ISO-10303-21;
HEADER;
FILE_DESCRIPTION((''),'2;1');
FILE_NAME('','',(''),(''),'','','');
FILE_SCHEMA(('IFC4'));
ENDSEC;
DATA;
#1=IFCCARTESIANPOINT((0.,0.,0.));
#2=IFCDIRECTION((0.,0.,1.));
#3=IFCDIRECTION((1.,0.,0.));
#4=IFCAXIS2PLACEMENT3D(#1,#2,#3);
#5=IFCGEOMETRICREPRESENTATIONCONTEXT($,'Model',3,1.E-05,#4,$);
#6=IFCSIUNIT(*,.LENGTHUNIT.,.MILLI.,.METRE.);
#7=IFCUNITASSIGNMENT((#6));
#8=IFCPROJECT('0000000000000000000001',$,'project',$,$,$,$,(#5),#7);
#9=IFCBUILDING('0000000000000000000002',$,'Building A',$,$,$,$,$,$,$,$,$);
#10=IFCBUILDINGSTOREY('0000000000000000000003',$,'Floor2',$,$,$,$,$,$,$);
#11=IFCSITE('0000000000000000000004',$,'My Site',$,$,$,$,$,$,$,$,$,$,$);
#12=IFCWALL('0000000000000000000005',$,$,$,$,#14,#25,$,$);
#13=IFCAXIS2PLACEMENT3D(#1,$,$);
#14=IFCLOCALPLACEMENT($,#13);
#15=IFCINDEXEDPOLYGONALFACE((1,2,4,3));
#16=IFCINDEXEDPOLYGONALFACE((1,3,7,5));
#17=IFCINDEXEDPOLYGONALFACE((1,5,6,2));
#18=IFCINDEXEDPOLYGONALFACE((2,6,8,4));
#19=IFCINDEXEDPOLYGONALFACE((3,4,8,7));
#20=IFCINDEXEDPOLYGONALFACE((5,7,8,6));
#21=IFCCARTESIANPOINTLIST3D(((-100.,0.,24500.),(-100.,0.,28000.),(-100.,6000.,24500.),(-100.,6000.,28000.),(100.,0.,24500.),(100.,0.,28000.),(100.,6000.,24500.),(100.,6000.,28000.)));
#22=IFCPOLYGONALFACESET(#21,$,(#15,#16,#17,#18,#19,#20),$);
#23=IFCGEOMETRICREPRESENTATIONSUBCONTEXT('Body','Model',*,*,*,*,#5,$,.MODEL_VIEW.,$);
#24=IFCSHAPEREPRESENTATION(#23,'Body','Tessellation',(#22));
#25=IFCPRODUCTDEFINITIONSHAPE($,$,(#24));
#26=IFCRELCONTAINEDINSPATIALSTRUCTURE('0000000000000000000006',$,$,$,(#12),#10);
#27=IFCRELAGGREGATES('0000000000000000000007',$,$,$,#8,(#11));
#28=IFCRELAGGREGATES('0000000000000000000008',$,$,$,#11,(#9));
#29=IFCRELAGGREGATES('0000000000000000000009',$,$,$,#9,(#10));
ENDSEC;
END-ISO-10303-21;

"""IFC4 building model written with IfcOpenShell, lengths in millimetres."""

from ifc_helpers import new_model, si_unit, frame, origin_with_axes, place, context, subcontext, project, spatial, indexed_curve, outline, extrude, element, save


model = new_model("IFC4")

# Units and contexts
model_context = context("Model", 3, precision=1e-05, world=origin_with_axes())
body_context = subcontext(model_context, "Body", "Model", "MODEL_VIEW")
ifc_project = project(units=[si_unit("LENGTHUNIT", "METRE", prefix="MILLI")], contexts=[model_context])

# Site, building, storey
site = spatial("IfcSite", under=ifc_project, Name="My Site")
building = spatial("IfcBuilding", under=site, Name="Building A")
storey = spatial("IfcBuildingStorey", under=building, Name="Floor2")

# Wall
wall_placement = place(None, frame((-100.0, 6000.0, 24500.0), z_axis=(0.0, 0.0, 1.0), x_axis=(0.0, -1.0, 0.0)))
element("IfcWall", 1, at=wall_placement, inside=storey, context=body_context, shape_type="SweptSolid", body=[
    extrude(outline(indexed_curve([(0.0, 0.0), (0.0, 200.0), (6000.0, 200.0), (6000.0, 0.0), (0.0, 0.0)], self_intersect=False)), origin_with_axes(), (0.0, 0.0, 1.0), 3500.0),
])

save(model, "model.ifc")
